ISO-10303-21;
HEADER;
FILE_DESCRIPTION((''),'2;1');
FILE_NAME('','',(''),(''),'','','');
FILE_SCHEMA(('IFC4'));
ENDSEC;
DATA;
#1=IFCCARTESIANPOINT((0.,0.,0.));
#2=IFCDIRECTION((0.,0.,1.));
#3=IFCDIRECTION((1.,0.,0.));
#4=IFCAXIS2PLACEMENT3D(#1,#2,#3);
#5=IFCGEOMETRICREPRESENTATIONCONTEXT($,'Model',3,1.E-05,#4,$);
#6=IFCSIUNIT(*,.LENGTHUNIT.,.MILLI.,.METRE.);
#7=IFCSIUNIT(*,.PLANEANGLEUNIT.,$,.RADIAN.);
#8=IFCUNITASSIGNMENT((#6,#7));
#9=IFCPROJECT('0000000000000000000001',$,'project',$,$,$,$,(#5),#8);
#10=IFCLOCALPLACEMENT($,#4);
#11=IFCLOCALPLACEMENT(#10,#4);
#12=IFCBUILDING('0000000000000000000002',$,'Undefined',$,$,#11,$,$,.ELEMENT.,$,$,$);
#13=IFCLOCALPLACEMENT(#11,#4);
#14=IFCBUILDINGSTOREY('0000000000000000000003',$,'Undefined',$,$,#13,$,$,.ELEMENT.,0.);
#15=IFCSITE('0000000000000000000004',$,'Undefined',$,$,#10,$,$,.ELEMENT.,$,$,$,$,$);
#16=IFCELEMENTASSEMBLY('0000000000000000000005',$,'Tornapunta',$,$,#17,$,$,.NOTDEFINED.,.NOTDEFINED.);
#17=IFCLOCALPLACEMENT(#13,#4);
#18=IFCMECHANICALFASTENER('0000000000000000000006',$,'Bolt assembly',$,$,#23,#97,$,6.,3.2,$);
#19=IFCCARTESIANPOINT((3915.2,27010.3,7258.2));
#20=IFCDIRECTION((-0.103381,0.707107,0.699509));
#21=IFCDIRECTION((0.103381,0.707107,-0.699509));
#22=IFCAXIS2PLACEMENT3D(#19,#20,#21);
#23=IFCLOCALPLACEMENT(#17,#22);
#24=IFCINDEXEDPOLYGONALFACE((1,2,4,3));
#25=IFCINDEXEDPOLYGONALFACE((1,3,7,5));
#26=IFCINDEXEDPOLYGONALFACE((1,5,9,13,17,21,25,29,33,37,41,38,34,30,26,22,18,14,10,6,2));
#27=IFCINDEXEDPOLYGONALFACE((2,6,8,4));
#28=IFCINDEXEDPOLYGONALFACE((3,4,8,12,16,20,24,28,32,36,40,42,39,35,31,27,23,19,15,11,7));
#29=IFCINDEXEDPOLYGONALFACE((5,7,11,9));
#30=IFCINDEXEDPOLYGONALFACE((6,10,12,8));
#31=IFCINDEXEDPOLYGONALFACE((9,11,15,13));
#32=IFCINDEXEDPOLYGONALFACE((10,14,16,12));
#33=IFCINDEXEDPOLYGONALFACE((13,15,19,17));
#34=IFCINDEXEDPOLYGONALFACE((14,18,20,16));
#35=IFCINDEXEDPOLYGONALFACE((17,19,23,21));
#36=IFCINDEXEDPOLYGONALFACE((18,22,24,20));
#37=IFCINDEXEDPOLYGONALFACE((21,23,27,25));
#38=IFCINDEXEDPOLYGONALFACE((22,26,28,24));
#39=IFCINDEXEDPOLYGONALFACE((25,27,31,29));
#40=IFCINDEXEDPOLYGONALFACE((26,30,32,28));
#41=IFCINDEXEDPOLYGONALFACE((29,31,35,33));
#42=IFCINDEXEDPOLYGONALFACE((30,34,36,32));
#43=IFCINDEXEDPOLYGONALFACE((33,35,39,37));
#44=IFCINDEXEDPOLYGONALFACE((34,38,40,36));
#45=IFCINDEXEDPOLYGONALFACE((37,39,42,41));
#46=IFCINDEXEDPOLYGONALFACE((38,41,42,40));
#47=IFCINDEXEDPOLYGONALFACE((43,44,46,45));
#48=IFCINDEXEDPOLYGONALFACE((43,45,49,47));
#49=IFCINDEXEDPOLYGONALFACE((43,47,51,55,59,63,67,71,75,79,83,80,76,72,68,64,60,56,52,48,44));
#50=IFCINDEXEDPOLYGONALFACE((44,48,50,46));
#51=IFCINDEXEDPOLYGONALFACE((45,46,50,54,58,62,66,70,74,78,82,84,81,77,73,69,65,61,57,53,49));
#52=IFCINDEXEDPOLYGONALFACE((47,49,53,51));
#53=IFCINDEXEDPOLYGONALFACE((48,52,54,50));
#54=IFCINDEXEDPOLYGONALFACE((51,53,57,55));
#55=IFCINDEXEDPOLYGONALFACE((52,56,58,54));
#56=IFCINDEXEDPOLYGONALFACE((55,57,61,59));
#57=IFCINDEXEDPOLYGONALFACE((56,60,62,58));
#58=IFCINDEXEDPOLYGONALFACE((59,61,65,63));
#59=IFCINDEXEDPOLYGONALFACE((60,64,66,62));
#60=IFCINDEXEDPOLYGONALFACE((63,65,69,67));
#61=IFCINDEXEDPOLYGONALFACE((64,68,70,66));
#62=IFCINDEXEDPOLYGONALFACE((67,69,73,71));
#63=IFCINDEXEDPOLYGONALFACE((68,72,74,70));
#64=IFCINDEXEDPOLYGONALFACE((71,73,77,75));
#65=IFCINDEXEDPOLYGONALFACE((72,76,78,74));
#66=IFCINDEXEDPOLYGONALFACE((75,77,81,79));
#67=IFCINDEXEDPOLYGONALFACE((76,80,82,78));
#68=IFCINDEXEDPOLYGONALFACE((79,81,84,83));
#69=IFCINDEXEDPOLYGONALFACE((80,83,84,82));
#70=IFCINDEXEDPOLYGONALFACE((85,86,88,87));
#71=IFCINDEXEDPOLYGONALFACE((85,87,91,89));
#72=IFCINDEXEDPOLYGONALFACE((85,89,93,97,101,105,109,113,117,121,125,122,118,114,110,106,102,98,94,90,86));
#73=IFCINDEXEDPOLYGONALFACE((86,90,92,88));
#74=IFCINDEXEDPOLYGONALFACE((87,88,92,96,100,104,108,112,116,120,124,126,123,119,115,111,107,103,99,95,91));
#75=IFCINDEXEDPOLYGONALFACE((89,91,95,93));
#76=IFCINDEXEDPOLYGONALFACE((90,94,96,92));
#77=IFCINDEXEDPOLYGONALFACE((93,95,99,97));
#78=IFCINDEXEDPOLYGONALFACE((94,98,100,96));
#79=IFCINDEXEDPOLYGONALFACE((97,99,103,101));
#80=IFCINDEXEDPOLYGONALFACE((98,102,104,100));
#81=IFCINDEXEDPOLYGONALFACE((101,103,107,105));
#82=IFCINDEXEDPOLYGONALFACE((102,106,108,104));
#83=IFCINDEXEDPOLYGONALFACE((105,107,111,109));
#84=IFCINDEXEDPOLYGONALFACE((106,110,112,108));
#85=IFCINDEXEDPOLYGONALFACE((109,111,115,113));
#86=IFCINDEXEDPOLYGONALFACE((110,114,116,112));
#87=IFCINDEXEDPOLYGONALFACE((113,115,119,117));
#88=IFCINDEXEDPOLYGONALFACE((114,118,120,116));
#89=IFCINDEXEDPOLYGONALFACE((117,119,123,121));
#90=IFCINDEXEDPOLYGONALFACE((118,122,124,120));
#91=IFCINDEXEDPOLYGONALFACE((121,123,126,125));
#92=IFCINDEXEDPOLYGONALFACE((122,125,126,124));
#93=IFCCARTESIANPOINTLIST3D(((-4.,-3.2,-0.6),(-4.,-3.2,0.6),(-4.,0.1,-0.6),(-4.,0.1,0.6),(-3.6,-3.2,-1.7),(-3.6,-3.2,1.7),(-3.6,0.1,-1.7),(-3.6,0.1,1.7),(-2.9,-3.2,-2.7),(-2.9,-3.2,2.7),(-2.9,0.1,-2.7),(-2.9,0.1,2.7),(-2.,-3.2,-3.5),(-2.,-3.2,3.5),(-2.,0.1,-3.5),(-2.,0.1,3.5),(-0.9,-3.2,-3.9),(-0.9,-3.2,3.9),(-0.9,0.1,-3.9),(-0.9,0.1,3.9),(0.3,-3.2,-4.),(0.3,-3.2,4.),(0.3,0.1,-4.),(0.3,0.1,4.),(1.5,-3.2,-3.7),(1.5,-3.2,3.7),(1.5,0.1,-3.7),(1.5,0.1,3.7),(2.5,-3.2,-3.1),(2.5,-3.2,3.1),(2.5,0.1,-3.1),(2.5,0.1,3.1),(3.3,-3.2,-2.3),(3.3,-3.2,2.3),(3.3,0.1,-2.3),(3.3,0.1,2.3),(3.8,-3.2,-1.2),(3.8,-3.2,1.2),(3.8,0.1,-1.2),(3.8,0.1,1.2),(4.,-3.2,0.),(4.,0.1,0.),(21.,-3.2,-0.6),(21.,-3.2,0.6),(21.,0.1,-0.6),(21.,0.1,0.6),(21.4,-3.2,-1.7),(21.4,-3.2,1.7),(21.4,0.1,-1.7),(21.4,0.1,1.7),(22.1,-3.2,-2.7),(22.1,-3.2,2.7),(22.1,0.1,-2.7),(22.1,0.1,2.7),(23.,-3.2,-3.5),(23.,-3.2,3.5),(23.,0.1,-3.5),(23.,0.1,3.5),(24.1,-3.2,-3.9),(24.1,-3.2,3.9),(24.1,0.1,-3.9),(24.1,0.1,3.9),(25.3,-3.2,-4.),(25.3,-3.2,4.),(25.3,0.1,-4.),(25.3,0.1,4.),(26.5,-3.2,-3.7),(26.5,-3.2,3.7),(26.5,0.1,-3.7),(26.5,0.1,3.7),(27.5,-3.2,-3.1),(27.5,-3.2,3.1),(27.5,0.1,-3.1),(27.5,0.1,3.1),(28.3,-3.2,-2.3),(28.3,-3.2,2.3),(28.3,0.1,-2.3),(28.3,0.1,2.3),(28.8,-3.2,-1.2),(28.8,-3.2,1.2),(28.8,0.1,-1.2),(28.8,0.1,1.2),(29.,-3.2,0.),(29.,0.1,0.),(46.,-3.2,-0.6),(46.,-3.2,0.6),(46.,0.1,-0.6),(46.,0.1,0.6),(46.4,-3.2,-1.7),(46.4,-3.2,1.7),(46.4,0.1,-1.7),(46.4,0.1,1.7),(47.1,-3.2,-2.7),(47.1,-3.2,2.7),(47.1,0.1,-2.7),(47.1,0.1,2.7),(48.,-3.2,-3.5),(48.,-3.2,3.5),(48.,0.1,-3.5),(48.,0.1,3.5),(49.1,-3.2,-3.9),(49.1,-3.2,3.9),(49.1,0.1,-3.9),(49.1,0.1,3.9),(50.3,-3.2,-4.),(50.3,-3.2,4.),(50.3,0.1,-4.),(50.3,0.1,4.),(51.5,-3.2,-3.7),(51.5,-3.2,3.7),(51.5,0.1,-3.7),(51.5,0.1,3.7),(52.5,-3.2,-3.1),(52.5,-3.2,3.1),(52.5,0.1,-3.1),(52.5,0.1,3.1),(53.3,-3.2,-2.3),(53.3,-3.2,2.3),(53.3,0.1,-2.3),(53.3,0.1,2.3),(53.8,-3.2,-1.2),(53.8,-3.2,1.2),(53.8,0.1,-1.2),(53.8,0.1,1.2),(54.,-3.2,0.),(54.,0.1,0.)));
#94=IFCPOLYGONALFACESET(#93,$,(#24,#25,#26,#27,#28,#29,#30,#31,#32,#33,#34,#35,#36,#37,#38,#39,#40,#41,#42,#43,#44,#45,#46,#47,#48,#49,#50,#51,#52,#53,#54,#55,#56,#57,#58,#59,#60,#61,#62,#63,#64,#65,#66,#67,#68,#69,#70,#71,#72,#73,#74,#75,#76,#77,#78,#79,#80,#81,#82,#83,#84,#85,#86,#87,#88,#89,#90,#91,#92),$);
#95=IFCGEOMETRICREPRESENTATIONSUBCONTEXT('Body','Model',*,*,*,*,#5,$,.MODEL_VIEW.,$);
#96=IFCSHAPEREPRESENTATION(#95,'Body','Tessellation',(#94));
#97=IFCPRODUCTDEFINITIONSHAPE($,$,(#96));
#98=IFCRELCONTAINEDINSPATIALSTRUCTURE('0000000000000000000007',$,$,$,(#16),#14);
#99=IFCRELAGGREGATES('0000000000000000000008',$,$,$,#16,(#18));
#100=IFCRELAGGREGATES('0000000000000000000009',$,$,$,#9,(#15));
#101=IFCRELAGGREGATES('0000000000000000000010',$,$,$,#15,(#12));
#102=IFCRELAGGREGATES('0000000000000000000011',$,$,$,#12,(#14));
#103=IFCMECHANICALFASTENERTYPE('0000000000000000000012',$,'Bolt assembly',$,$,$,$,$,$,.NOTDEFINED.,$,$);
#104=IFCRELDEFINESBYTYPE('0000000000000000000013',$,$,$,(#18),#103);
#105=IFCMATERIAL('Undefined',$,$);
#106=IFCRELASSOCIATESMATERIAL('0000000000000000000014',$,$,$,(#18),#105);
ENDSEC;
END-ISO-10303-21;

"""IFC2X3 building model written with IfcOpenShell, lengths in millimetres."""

from ifc_helpers import new_model, si_unit, frame, origin_with_axes, origin_2d_with_axis, place, context, subcontext, project, spatial, circle, extrude, source, transform, mapped, material, type_object, element, aggregate, save


model = new_model("IFC2X3")

# Units and contexts
model_context = context("Model", 3, precision=1e-05, world=origin_with_axes())
body_context = subcontext(model_context, "Body", "Model", "MODEL_VIEW")
ifc_project = project(units=[si_unit("LENGTHUNIT", "METRE", prefix="MILLI"), si_unit("PLANEANGLEUNIT", "RADIAN")], contexts=[model_context])

# Site, building, storey
site_placement = place(None, origin_with_axes())
site = spatial("IfcSite", under=ifc_project, at=site_placement, Name="Undefined", CompositionType="ELEMENT")
building_placement = place(site_placement, origin_with_axes())
building = spatial("IfcBuilding", under=site, at=building_placement, Name="Undefined", CompositionType="ELEMENT")
storey_placement = place(building_placement, origin_with_axes())
storey = spatial("IfcBuildingStorey", under=building, at=storey_placement, Name="Undefined", CompositionType="ELEMENT", Elevation=0.0)

# Shared definitions
ifc_material_1 = material(Name="Undefined")
mechanical_fastener_type = type_object("IfcMechanicalFastenerType", Name="Bolt assembly")

# Element assembly, mechanical fastener
shared_shape_1 = source(origin_with_axes(), body_context, "Body", "SweptSolid", [
    extrude(circle(Radius=4.0, at=origin_2d_with_axis()), frame((0.0, -3.2, 0.0), z_axis=(0.0, 1.0, 0.0), x_axis=(1.0, 0.0, 0.0)), (0.0, 0.0, 1.0), 3.3),
])
assembly_1_placement = place(storey_placement, origin_with_axes())
assembly_1 = element("IfcElementAssembly", 1, at=assembly_1_placement, inside=storey, Name="Tornapunta", AssemblyPlace="NOTDEFINED", PredefinedType="NOTDEFINED")
mechanical_fastener_1_placement = place(assembly_1_placement, frame((3915.2, 27010.3, 7258.2), z_axis=(-0.103381, 0.707107, 0.699509), x_axis=(0.103381, 0.707107, -0.699509)))
mechanical_fastener_1 = element("IfcMechanicalFastener", 2, at=mechanical_fastener_1_placement, type_object=mechanical_fastener_type, material=ifc_material_1, Name="Bolt assembly", NominalDiameter=6.0, NominalLength=3.2, context=body_context, shape_type="MappedRepresentation", body=[
    mapped(shared_shape_1, transform((0.0, 0.0, 0.0))),
    mapped(shared_shape_1, transform((25.0, 0.0, 0.0))),
    mapped(shared_shape_1, transform((50.0, 0.0, 0.0))),
])
aggregate(assembly_1, [mechanical_fastener_1])

save(model, "model.ifc")
